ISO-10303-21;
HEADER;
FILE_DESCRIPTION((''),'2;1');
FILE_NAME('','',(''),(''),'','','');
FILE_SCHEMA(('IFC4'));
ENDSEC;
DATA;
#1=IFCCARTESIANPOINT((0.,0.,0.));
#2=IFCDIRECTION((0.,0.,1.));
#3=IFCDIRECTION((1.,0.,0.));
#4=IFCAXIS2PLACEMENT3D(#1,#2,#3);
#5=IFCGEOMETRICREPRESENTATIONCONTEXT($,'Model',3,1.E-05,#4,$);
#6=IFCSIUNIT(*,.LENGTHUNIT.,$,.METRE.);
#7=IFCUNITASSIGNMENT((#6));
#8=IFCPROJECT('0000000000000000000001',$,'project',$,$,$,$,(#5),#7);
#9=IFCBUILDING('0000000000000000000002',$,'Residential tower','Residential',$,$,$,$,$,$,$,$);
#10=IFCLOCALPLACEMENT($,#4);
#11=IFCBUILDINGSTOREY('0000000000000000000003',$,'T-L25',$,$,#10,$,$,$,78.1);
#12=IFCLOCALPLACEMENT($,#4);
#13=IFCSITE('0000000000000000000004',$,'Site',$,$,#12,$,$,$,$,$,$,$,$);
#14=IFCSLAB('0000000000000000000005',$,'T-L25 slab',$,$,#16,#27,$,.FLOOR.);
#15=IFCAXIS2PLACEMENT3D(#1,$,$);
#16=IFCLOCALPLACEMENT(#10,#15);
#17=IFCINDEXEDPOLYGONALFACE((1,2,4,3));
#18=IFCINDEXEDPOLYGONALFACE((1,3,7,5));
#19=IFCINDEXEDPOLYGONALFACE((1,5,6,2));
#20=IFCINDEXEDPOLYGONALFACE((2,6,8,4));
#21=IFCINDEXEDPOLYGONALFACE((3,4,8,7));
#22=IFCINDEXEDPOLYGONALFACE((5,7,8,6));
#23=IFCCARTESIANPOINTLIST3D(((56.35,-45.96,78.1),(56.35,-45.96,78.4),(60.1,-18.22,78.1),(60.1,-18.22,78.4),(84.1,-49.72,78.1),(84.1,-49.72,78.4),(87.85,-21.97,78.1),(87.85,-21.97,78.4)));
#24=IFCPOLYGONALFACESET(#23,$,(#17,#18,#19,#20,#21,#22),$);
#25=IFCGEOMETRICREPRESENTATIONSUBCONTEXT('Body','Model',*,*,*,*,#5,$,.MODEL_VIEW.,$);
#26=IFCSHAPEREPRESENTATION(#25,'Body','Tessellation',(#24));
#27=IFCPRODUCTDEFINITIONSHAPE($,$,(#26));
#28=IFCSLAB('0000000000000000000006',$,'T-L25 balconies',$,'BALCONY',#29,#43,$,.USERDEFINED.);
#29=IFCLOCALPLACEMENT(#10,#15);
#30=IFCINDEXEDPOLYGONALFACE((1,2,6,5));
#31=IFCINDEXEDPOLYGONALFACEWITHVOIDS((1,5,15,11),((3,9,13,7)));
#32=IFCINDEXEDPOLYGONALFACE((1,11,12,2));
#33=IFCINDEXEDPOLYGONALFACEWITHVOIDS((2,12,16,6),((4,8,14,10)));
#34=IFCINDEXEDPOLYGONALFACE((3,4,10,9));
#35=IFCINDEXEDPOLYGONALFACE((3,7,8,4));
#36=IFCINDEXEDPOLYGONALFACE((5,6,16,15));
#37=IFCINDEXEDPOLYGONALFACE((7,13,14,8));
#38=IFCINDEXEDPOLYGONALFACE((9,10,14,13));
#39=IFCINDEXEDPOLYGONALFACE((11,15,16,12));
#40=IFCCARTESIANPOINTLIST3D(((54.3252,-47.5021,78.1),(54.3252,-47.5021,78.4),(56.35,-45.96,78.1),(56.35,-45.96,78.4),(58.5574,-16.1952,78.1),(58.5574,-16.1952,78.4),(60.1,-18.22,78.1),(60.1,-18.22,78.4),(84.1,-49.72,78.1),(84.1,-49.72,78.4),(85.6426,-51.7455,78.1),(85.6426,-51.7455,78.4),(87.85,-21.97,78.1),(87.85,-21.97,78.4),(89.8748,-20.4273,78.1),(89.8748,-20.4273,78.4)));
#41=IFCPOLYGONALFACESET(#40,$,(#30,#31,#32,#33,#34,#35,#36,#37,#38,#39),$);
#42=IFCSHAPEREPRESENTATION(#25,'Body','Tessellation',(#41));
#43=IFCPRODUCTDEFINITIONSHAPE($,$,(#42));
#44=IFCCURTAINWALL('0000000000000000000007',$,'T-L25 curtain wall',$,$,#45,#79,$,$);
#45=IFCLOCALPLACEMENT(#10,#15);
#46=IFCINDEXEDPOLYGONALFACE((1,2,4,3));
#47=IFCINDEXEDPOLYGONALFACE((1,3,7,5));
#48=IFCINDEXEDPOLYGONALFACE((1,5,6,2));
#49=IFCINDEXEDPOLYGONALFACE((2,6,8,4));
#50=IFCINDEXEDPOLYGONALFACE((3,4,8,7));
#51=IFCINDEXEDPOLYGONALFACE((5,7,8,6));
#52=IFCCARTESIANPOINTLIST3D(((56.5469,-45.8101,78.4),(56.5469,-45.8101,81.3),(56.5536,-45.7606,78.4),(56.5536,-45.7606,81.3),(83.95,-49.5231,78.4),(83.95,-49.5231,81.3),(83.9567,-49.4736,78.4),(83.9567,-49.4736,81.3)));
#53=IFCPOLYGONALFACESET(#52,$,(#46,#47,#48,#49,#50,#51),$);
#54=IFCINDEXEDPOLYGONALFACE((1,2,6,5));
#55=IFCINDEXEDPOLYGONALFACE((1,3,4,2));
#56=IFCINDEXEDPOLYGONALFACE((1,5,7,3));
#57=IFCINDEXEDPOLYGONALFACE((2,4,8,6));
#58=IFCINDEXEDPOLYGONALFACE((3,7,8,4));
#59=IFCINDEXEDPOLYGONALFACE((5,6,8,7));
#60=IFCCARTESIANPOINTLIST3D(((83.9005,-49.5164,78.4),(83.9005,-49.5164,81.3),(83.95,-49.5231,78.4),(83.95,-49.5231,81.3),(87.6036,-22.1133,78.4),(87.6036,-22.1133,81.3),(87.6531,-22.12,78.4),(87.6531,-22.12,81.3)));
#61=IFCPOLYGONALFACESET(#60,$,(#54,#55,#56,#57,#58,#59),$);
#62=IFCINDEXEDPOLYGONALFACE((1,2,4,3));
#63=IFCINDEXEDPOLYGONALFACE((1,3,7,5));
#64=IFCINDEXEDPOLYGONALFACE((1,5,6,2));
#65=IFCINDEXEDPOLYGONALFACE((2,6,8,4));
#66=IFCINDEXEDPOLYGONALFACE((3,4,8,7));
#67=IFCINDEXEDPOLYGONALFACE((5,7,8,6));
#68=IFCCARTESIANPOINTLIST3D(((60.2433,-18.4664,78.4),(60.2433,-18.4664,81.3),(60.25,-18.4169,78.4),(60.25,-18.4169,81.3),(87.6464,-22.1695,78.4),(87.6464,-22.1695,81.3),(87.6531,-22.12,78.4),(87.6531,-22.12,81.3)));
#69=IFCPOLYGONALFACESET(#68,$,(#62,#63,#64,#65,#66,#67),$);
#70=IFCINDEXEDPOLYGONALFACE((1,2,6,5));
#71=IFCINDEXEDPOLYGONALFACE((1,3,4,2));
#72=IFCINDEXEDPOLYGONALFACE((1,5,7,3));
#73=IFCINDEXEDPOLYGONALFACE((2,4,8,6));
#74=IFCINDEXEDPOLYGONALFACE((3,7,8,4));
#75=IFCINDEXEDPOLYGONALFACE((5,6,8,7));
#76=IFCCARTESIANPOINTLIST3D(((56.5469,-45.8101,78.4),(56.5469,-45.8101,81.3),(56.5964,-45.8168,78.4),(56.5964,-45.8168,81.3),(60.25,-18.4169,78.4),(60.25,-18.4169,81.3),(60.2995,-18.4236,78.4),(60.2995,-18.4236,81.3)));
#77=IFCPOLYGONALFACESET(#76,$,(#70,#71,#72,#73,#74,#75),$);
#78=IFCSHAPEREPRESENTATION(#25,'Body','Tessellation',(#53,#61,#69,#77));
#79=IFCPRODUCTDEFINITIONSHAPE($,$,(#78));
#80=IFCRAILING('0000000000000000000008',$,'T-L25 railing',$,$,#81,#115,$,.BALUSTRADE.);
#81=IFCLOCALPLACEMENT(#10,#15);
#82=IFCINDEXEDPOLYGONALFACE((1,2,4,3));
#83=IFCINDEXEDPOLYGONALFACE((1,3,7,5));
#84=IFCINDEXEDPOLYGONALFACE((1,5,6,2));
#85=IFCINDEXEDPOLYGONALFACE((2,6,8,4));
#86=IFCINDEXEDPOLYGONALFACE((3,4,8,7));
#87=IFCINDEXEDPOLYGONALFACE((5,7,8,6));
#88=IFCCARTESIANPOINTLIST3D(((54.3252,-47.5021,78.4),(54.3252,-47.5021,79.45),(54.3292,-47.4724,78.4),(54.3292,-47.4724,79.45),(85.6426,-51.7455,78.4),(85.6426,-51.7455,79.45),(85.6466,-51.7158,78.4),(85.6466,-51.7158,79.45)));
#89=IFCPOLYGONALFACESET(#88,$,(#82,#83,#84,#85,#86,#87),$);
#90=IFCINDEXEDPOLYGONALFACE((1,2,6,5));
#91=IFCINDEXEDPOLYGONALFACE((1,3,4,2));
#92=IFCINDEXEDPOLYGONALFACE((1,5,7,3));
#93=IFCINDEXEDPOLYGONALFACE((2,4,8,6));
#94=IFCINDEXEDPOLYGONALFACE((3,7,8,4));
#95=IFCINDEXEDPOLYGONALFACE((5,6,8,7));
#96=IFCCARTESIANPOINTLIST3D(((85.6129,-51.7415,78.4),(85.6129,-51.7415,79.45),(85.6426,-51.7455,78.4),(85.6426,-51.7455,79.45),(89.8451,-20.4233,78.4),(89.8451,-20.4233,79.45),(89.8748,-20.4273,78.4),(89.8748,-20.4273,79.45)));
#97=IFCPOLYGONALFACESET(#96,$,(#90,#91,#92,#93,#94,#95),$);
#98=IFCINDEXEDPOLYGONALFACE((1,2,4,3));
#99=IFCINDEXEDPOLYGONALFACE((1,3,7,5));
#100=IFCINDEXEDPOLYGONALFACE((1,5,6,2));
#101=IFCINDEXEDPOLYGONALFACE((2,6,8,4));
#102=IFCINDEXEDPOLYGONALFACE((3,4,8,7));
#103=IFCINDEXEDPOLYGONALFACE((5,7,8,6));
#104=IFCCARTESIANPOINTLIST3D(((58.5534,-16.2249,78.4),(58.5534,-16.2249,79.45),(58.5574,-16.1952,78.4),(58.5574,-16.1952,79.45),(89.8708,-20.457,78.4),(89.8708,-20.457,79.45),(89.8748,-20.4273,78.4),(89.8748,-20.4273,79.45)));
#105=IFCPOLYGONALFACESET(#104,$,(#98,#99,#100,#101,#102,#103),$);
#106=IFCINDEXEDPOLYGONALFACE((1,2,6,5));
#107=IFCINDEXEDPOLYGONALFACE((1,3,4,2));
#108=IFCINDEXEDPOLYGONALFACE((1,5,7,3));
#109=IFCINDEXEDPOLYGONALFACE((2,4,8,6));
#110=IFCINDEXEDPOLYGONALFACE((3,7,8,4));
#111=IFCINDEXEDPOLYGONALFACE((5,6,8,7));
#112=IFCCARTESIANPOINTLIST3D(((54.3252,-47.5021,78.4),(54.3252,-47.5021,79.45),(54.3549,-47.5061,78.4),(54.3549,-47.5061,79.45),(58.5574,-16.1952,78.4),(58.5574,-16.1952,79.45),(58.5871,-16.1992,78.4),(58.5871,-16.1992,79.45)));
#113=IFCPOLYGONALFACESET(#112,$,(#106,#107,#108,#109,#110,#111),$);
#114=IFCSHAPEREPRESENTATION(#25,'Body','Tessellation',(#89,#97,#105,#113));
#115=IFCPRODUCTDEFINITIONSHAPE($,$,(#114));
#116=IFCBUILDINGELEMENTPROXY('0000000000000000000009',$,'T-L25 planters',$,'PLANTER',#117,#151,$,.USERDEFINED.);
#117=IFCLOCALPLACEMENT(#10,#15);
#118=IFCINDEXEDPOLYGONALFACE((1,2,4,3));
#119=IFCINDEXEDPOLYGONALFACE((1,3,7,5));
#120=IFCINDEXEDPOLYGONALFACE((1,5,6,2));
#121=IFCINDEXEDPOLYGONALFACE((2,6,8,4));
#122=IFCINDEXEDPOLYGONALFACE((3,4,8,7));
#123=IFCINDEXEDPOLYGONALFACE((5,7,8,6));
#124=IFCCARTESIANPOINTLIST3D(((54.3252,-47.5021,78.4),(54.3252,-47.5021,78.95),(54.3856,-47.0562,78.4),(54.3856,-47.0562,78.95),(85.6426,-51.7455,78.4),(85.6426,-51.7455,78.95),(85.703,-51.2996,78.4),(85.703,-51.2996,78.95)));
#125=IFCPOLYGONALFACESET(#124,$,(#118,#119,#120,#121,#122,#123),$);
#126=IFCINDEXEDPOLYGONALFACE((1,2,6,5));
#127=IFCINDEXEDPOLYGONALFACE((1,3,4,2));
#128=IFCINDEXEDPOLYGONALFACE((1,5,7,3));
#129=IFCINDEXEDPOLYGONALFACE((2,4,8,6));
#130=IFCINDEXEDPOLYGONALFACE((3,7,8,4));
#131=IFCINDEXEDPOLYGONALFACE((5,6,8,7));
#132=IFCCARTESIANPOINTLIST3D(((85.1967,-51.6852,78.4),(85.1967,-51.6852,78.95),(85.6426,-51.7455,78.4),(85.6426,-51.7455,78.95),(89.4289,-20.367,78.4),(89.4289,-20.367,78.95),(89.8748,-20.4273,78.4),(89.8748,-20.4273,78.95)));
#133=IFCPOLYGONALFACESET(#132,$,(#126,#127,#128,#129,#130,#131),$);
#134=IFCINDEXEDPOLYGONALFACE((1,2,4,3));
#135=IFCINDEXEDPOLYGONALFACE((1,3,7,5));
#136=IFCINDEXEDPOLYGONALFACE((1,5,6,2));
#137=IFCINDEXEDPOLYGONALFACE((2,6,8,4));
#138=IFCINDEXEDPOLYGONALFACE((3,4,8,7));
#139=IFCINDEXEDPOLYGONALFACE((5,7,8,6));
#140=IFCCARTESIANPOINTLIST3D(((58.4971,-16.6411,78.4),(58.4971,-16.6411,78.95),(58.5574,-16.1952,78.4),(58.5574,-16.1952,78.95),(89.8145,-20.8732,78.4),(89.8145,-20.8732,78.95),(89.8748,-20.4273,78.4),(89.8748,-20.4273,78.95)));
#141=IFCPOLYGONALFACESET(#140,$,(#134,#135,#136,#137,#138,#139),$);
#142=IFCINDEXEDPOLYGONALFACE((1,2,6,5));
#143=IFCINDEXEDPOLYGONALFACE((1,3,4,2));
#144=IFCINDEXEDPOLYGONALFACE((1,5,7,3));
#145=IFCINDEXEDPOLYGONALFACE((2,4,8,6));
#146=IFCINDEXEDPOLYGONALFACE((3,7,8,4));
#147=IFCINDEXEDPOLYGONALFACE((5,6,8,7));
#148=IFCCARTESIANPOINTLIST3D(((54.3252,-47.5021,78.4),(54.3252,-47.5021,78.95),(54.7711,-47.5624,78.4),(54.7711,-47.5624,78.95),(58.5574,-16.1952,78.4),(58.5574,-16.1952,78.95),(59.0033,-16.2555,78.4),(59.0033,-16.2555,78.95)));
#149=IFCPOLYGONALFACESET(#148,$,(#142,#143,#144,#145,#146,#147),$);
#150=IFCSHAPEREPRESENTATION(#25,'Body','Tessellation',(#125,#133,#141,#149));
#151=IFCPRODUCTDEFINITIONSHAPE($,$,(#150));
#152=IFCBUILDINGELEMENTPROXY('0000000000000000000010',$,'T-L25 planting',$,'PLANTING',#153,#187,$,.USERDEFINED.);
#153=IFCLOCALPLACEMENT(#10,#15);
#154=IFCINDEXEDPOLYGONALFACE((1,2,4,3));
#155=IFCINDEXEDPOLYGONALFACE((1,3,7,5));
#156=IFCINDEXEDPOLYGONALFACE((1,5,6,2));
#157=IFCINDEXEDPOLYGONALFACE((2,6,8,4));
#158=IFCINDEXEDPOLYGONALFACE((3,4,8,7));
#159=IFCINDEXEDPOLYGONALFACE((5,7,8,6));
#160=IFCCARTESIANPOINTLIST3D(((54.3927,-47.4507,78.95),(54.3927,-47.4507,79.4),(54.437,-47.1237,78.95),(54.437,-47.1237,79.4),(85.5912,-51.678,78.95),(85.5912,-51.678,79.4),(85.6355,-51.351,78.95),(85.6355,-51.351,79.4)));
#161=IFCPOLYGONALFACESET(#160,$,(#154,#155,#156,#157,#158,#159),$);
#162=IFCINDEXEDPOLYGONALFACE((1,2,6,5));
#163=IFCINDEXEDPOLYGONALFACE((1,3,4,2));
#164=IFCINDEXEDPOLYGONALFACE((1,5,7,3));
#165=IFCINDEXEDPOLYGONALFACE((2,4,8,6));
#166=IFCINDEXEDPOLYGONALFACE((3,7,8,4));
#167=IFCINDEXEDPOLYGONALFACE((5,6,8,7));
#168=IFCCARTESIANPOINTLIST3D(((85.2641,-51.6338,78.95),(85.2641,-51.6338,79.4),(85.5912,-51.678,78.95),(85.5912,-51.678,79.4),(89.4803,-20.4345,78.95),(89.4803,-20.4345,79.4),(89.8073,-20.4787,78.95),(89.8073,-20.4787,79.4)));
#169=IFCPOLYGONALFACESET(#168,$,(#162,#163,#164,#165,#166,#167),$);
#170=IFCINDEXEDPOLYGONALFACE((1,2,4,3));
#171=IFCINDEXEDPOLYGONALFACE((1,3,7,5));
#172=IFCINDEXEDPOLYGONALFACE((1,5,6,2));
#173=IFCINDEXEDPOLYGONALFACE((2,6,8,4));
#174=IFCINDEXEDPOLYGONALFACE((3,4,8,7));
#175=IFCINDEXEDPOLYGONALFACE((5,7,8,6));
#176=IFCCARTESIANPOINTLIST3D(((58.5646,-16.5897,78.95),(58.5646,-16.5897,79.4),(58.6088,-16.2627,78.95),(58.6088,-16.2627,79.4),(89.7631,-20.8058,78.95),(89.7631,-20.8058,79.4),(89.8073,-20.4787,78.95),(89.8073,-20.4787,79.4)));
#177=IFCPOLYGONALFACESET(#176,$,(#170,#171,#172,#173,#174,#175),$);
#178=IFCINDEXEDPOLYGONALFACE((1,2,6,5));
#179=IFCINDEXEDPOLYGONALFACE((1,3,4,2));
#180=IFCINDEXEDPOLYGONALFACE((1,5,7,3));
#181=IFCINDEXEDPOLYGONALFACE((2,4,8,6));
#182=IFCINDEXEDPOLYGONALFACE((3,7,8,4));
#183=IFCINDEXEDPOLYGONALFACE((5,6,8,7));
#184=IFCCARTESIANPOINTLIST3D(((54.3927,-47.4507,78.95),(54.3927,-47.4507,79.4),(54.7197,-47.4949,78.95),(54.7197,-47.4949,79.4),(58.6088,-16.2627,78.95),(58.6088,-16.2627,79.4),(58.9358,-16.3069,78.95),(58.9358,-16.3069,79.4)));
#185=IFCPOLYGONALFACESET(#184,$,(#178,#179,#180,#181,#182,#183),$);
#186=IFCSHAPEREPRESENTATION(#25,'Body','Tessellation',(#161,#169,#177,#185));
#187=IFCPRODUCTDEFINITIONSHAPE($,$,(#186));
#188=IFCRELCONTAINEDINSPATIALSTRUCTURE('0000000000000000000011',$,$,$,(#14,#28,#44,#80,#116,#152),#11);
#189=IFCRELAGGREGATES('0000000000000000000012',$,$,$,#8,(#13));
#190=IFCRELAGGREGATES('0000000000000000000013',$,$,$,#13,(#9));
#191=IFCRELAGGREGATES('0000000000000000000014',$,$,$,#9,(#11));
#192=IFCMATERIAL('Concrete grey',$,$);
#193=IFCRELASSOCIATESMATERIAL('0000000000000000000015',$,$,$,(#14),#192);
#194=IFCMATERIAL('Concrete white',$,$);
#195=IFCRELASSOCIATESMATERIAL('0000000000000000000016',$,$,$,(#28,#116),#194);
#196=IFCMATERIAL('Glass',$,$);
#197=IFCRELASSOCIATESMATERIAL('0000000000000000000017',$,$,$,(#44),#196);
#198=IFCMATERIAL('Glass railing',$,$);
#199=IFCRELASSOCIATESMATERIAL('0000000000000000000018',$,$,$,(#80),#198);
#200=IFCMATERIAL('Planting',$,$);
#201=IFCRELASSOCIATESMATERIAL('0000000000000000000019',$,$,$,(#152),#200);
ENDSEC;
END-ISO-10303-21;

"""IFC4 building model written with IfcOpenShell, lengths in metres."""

from ifc_helpers import new_model, si_unit, frame, origin_with_axes, place, context, subcontext, project, spatial, polyline, outline, extrude, material, element, save


model = new_model("IFC4")

# Units and contexts
model_context = context("Model", 3, precision=1e-05, world=origin_with_axes())
body_context = subcontext(model_context, "Body", "Model", "MODEL_VIEW")
ifc_project = project(units=[si_unit("LENGTHUNIT", "METRE")], contexts=[model_context])

# Site, building, storey
site_placement = place(None, origin_with_axes())
site = spatial("IfcSite", under=ifc_project, at=site_placement, Name="Site")
building = spatial("IfcBuilding", under=site, Name="Residential tower", Description="Residential")
storey_placement = place(None, origin_with_axes())
storey = spatial("IfcBuildingStorey", under=building, at=storey_placement, Name="T-L25", Elevation=78.1)

# Slabs
ifc_material_1 = material(Name="Concrete grey")
slab_1_placement = place(storey_placement, origin_with_axes())
element("IfcSlab", 1, at=slab_1_placement, inside=storey, material=ifc_material_1, Name="T-L25 slab", PredefinedType="FLOOR", context=body_context, shape_type="SweptSolid", body=[
    extrude(outline(polyline([(56.35, -45.96), (84.1, -49.72), (87.85, -21.97), (60.1, -18.22), (56.35, -45.96)])), frame((0.0, 0.0, 78.1), z_axis=(0.0, 0.0, 1.0), x_axis=(1.0, 0.0, 0.0)), (0.0, 0.0, 1.0), 0.3),
])
ifc_material_2 = material(Name="Concrete white")
slab_2_placement = place(storey_placement, origin_with_axes())
element("IfcSlab", 2, at=slab_2_placement, inside=storey, material=ifc_material_2, Name="T-L25 balconies", ObjectType="BALCONY", PredefinedType="USERDEFINED", context=body_context, shape_type="SweptSolid", body=[
    extrude(outline(polyline([(54.3252, -47.5021), (85.6426, -51.7455), (89.8748, -20.4273), (58.5574, -16.1952), (54.3252, -47.5021)]), holes=[polyline([(56.35, -45.96), (84.1, -49.72), (87.85, -21.97), (60.1, -18.22), (56.35, -45.96)])]), frame((0.0, 0.0, 78.1), z_axis=(0.0, 0.0, 1.0), x_axis=(1.0, 0.0, 0.0)), (0.0, 0.0, 1.0), 0.3),
])

# Curtain wall
ifc_material_3 = material(Name="Glass")
curtain_wall_placement = place(storey_placement, origin_with_axes())
element("IfcCurtainWall", 3, at=curtain_wall_placement, inside=storey, material=ifc_material_3, Name="T-L25 curtain wall", context=body_context, shape_type="SweptSolid", body=[
    extrude(outline(polyline([(56.5469, -45.8101), (83.95, -49.5231), (83.9567, -49.4736), (56.5536, -45.7606), (56.5469, -45.8101)])), frame((0.0, 0.0, 78.4), z_axis=(0.0, 0.0, 1.0), x_axis=(1.0, 0.0, 0.0)), (0.0, 0.0, 1.0), 2.9),
    extrude(outline(polyline([(83.95, -49.5231), (87.6531, -22.12), (87.6036, -22.1133), (83.9005, -49.5164), (83.95, -49.5231)])), frame((0.0, 0.0, 78.4), z_axis=(0.0, 0.0, 1.0), x_axis=(1.0, 0.0, 0.0)), (0.0, 0.0, 1.0), 2.9),
    extrude(outline(polyline([(87.6531, -22.12), (60.25, -18.4169), (60.2433, -18.4664), (87.6464, -22.1695), (87.6531, -22.12)])), frame((0.0, 0.0, 78.4), z_axis=(0.0, 0.0, 1.0), x_axis=(1.0, 0.0, 0.0)), (0.0, 0.0, 1.0), 2.9),
    extrude(outline(polyline([(60.25, -18.4169), (56.5469, -45.8101), (56.5964, -45.8168), (60.2995, -18.4236), (60.25, -18.4169)])), frame((0.0, 0.0, 78.4), z_axis=(0.0, 0.0, 1.0), x_axis=(1.0, 0.0, 0.0)), (0.0, 0.0, 1.0), 2.9),
])

# Railing
ifc_material_4 = material(Name="Glass railing")
railing_placement = place(storey_placement, origin_with_axes())
element("IfcRailing", 4, at=railing_placement, inside=storey, material=ifc_material_4, Name="T-L25 railing", PredefinedType="BALUSTRADE", context=body_context, shape_type="SweptSolid", body=[
    extrude(outline(polyline([(54.3252, -47.5021), (85.6426, -51.7455), (85.6466, -51.7158), (54.3292, -47.4724), (54.3252, -47.5021)])), frame((0.0, 0.0, 78.4), z_axis=(0.0, 0.0, 1.0), x_axis=(1.0, 0.0, 0.0)), (0.0, 0.0, 1.0), 1.05),
    extrude(outline(polyline([(85.6426, -51.7455), (89.8748, -20.4273), (89.8451, -20.4233), (85.6129, -51.7415), (85.6426, -51.7455)])), frame((0.0, 0.0, 78.4), z_axis=(0.0, 0.0, 1.0), x_axis=(1.0, 0.0, 0.0)), (0.0, 0.0, 1.0), 1.05),
    extrude(outline(polyline([(89.8748, -20.4273), (58.5574, -16.1952), (58.5534, -16.2249), (89.8708, -20.457), (89.8748, -20.4273)])), frame((0.0, 0.0, 78.4), z_axis=(0.0, 0.0, 1.0), x_axis=(1.0, 0.0, 0.0)), (0.0, 0.0, 1.0), 1.05),
    extrude(outline(polyline([(58.5574, -16.1952), (54.3252, -47.5021), (54.3549, -47.5061), (58.5871, -16.1992), (58.5574, -16.1952)])), frame((0.0, 0.0, 78.4), z_axis=(0.0, 0.0, 1.0), x_axis=(1.0, 0.0, 0.0)), (0.0, 0.0, 1.0), 1.05),
])

# Building element proxies
proxy_1_placement = place(storey_placement, origin_with_axes())
element("IfcBuildingElementProxy", 5, at=proxy_1_placement, inside=storey, material=ifc_material_2, Name="T-L25 planters", ObjectType="PLANTER", PredefinedType="USERDEFINED", context=body_context, shape_type="SweptSolid", body=[
    extrude(outline(polyline([(54.3252, -47.5021), (85.6426, -51.7455), (85.703, -51.2996), (54.3856, -47.0562), (54.3252, -47.5021)])), frame((0.0, 0.0, 78.4), z_axis=(0.0, 0.0, 1.0), x_axis=(1.0, 0.0, 0.0)), (0.0, 0.0, 1.0), 0.55),
    extrude(outline(polyline([(85.6426, -51.7455), (89.8748, -20.4273), (89.4289, -20.367), (85.1967, -51.6852), (85.6426, -51.7455)])), frame((0.0, 0.0, 78.4), z_axis=(0.0, 0.0, 1.0), x_axis=(1.0, 0.0, 0.0)), (0.0, 0.0, 1.0), 0.55),
    extrude(outline(polyline([(89.8748, -20.4273), (58.5574, -16.1952), (58.4971, -16.6411), (89.8145, -20.8732), (89.8748, -20.4273)])), frame((0.0, 0.0, 78.4), z_axis=(0.0, 0.0, 1.0), x_axis=(1.0, 0.0, 0.0)), (0.0, 0.0, 1.0), 0.55),
    extrude(outline(polyline([(58.5574, -16.1952), (54.3252, -47.5021), (54.7711, -47.5624), (59.0033, -16.2555), (58.5574, -16.1952)])), frame((0.0, 0.0, 78.4), z_axis=(0.0, 0.0, 1.0), x_axis=(1.0, 0.0, 0.0)), (0.0, 0.0, 1.0), 0.55),
])
ifc_material_5 = material(Name="Planting")
proxy_2_placement = place(storey_placement, origin_with_axes())
element("IfcBuildingElementProxy", 6, at=proxy_2_placement, inside=storey, material=ifc_material_5, Name="T-L25 planting", ObjectType="PLANTING", PredefinedType="USERDEFINED", context=body_context, shape_type="SweptSolid", body=[
    extrude(outline(polyline([(54.3927, -47.4507), (85.5912, -51.678), (85.6355, -51.351), (54.437, -47.1237), (54.3927, -47.4507)])), frame((0.0, 0.0, 78.95), z_axis=(0.0, 0.0, 1.0), x_axis=(1.0, 0.0, 0.0)), (0.0, 0.0, 1.0), 0.45),
    extrude(outline(polyline([(85.5912, -51.678), (89.8073, -20.4787), (89.4803, -20.4345), (85.2641, -51.6338), (85.5912, -51.678)])), frame((0.0, 0.0, 78.95), z_axis=(0.0, 0.0, 1.0), x_axis=(1.0, 0.0, 0.0)), (0.0, 0.0, 1.0), 0.45),
    extrude(outline(polyline([(89.8073, -20.4787), (58.6088, -16.2627), (58.5646, -16.5897), (89.7631, -20.8058), (89.8073, -20.4787)])), frame((0.0, 0.0, 78.95), z_axis=(0.0, 0.0, 1.0), x_axis=(1.0, 0.0, 0.0)), (0.0, 0.0, 1.0), 0.45),
    extrude(outline(polyline([(58.6088, -16.2627), (54.3927, -47.4507), (54.7197, -47.4949), (58.9358, -16.3069), (58.6088, -16.2627)])), frame((0.0, 0.0, 78.95), z_axis=(0.0, 0.0, 1.0), x_axis=(1.0, 0.0, 0.0)), (0.0, 0.0, 1.0), 0.45),
])

save(model, "model.ifc")
